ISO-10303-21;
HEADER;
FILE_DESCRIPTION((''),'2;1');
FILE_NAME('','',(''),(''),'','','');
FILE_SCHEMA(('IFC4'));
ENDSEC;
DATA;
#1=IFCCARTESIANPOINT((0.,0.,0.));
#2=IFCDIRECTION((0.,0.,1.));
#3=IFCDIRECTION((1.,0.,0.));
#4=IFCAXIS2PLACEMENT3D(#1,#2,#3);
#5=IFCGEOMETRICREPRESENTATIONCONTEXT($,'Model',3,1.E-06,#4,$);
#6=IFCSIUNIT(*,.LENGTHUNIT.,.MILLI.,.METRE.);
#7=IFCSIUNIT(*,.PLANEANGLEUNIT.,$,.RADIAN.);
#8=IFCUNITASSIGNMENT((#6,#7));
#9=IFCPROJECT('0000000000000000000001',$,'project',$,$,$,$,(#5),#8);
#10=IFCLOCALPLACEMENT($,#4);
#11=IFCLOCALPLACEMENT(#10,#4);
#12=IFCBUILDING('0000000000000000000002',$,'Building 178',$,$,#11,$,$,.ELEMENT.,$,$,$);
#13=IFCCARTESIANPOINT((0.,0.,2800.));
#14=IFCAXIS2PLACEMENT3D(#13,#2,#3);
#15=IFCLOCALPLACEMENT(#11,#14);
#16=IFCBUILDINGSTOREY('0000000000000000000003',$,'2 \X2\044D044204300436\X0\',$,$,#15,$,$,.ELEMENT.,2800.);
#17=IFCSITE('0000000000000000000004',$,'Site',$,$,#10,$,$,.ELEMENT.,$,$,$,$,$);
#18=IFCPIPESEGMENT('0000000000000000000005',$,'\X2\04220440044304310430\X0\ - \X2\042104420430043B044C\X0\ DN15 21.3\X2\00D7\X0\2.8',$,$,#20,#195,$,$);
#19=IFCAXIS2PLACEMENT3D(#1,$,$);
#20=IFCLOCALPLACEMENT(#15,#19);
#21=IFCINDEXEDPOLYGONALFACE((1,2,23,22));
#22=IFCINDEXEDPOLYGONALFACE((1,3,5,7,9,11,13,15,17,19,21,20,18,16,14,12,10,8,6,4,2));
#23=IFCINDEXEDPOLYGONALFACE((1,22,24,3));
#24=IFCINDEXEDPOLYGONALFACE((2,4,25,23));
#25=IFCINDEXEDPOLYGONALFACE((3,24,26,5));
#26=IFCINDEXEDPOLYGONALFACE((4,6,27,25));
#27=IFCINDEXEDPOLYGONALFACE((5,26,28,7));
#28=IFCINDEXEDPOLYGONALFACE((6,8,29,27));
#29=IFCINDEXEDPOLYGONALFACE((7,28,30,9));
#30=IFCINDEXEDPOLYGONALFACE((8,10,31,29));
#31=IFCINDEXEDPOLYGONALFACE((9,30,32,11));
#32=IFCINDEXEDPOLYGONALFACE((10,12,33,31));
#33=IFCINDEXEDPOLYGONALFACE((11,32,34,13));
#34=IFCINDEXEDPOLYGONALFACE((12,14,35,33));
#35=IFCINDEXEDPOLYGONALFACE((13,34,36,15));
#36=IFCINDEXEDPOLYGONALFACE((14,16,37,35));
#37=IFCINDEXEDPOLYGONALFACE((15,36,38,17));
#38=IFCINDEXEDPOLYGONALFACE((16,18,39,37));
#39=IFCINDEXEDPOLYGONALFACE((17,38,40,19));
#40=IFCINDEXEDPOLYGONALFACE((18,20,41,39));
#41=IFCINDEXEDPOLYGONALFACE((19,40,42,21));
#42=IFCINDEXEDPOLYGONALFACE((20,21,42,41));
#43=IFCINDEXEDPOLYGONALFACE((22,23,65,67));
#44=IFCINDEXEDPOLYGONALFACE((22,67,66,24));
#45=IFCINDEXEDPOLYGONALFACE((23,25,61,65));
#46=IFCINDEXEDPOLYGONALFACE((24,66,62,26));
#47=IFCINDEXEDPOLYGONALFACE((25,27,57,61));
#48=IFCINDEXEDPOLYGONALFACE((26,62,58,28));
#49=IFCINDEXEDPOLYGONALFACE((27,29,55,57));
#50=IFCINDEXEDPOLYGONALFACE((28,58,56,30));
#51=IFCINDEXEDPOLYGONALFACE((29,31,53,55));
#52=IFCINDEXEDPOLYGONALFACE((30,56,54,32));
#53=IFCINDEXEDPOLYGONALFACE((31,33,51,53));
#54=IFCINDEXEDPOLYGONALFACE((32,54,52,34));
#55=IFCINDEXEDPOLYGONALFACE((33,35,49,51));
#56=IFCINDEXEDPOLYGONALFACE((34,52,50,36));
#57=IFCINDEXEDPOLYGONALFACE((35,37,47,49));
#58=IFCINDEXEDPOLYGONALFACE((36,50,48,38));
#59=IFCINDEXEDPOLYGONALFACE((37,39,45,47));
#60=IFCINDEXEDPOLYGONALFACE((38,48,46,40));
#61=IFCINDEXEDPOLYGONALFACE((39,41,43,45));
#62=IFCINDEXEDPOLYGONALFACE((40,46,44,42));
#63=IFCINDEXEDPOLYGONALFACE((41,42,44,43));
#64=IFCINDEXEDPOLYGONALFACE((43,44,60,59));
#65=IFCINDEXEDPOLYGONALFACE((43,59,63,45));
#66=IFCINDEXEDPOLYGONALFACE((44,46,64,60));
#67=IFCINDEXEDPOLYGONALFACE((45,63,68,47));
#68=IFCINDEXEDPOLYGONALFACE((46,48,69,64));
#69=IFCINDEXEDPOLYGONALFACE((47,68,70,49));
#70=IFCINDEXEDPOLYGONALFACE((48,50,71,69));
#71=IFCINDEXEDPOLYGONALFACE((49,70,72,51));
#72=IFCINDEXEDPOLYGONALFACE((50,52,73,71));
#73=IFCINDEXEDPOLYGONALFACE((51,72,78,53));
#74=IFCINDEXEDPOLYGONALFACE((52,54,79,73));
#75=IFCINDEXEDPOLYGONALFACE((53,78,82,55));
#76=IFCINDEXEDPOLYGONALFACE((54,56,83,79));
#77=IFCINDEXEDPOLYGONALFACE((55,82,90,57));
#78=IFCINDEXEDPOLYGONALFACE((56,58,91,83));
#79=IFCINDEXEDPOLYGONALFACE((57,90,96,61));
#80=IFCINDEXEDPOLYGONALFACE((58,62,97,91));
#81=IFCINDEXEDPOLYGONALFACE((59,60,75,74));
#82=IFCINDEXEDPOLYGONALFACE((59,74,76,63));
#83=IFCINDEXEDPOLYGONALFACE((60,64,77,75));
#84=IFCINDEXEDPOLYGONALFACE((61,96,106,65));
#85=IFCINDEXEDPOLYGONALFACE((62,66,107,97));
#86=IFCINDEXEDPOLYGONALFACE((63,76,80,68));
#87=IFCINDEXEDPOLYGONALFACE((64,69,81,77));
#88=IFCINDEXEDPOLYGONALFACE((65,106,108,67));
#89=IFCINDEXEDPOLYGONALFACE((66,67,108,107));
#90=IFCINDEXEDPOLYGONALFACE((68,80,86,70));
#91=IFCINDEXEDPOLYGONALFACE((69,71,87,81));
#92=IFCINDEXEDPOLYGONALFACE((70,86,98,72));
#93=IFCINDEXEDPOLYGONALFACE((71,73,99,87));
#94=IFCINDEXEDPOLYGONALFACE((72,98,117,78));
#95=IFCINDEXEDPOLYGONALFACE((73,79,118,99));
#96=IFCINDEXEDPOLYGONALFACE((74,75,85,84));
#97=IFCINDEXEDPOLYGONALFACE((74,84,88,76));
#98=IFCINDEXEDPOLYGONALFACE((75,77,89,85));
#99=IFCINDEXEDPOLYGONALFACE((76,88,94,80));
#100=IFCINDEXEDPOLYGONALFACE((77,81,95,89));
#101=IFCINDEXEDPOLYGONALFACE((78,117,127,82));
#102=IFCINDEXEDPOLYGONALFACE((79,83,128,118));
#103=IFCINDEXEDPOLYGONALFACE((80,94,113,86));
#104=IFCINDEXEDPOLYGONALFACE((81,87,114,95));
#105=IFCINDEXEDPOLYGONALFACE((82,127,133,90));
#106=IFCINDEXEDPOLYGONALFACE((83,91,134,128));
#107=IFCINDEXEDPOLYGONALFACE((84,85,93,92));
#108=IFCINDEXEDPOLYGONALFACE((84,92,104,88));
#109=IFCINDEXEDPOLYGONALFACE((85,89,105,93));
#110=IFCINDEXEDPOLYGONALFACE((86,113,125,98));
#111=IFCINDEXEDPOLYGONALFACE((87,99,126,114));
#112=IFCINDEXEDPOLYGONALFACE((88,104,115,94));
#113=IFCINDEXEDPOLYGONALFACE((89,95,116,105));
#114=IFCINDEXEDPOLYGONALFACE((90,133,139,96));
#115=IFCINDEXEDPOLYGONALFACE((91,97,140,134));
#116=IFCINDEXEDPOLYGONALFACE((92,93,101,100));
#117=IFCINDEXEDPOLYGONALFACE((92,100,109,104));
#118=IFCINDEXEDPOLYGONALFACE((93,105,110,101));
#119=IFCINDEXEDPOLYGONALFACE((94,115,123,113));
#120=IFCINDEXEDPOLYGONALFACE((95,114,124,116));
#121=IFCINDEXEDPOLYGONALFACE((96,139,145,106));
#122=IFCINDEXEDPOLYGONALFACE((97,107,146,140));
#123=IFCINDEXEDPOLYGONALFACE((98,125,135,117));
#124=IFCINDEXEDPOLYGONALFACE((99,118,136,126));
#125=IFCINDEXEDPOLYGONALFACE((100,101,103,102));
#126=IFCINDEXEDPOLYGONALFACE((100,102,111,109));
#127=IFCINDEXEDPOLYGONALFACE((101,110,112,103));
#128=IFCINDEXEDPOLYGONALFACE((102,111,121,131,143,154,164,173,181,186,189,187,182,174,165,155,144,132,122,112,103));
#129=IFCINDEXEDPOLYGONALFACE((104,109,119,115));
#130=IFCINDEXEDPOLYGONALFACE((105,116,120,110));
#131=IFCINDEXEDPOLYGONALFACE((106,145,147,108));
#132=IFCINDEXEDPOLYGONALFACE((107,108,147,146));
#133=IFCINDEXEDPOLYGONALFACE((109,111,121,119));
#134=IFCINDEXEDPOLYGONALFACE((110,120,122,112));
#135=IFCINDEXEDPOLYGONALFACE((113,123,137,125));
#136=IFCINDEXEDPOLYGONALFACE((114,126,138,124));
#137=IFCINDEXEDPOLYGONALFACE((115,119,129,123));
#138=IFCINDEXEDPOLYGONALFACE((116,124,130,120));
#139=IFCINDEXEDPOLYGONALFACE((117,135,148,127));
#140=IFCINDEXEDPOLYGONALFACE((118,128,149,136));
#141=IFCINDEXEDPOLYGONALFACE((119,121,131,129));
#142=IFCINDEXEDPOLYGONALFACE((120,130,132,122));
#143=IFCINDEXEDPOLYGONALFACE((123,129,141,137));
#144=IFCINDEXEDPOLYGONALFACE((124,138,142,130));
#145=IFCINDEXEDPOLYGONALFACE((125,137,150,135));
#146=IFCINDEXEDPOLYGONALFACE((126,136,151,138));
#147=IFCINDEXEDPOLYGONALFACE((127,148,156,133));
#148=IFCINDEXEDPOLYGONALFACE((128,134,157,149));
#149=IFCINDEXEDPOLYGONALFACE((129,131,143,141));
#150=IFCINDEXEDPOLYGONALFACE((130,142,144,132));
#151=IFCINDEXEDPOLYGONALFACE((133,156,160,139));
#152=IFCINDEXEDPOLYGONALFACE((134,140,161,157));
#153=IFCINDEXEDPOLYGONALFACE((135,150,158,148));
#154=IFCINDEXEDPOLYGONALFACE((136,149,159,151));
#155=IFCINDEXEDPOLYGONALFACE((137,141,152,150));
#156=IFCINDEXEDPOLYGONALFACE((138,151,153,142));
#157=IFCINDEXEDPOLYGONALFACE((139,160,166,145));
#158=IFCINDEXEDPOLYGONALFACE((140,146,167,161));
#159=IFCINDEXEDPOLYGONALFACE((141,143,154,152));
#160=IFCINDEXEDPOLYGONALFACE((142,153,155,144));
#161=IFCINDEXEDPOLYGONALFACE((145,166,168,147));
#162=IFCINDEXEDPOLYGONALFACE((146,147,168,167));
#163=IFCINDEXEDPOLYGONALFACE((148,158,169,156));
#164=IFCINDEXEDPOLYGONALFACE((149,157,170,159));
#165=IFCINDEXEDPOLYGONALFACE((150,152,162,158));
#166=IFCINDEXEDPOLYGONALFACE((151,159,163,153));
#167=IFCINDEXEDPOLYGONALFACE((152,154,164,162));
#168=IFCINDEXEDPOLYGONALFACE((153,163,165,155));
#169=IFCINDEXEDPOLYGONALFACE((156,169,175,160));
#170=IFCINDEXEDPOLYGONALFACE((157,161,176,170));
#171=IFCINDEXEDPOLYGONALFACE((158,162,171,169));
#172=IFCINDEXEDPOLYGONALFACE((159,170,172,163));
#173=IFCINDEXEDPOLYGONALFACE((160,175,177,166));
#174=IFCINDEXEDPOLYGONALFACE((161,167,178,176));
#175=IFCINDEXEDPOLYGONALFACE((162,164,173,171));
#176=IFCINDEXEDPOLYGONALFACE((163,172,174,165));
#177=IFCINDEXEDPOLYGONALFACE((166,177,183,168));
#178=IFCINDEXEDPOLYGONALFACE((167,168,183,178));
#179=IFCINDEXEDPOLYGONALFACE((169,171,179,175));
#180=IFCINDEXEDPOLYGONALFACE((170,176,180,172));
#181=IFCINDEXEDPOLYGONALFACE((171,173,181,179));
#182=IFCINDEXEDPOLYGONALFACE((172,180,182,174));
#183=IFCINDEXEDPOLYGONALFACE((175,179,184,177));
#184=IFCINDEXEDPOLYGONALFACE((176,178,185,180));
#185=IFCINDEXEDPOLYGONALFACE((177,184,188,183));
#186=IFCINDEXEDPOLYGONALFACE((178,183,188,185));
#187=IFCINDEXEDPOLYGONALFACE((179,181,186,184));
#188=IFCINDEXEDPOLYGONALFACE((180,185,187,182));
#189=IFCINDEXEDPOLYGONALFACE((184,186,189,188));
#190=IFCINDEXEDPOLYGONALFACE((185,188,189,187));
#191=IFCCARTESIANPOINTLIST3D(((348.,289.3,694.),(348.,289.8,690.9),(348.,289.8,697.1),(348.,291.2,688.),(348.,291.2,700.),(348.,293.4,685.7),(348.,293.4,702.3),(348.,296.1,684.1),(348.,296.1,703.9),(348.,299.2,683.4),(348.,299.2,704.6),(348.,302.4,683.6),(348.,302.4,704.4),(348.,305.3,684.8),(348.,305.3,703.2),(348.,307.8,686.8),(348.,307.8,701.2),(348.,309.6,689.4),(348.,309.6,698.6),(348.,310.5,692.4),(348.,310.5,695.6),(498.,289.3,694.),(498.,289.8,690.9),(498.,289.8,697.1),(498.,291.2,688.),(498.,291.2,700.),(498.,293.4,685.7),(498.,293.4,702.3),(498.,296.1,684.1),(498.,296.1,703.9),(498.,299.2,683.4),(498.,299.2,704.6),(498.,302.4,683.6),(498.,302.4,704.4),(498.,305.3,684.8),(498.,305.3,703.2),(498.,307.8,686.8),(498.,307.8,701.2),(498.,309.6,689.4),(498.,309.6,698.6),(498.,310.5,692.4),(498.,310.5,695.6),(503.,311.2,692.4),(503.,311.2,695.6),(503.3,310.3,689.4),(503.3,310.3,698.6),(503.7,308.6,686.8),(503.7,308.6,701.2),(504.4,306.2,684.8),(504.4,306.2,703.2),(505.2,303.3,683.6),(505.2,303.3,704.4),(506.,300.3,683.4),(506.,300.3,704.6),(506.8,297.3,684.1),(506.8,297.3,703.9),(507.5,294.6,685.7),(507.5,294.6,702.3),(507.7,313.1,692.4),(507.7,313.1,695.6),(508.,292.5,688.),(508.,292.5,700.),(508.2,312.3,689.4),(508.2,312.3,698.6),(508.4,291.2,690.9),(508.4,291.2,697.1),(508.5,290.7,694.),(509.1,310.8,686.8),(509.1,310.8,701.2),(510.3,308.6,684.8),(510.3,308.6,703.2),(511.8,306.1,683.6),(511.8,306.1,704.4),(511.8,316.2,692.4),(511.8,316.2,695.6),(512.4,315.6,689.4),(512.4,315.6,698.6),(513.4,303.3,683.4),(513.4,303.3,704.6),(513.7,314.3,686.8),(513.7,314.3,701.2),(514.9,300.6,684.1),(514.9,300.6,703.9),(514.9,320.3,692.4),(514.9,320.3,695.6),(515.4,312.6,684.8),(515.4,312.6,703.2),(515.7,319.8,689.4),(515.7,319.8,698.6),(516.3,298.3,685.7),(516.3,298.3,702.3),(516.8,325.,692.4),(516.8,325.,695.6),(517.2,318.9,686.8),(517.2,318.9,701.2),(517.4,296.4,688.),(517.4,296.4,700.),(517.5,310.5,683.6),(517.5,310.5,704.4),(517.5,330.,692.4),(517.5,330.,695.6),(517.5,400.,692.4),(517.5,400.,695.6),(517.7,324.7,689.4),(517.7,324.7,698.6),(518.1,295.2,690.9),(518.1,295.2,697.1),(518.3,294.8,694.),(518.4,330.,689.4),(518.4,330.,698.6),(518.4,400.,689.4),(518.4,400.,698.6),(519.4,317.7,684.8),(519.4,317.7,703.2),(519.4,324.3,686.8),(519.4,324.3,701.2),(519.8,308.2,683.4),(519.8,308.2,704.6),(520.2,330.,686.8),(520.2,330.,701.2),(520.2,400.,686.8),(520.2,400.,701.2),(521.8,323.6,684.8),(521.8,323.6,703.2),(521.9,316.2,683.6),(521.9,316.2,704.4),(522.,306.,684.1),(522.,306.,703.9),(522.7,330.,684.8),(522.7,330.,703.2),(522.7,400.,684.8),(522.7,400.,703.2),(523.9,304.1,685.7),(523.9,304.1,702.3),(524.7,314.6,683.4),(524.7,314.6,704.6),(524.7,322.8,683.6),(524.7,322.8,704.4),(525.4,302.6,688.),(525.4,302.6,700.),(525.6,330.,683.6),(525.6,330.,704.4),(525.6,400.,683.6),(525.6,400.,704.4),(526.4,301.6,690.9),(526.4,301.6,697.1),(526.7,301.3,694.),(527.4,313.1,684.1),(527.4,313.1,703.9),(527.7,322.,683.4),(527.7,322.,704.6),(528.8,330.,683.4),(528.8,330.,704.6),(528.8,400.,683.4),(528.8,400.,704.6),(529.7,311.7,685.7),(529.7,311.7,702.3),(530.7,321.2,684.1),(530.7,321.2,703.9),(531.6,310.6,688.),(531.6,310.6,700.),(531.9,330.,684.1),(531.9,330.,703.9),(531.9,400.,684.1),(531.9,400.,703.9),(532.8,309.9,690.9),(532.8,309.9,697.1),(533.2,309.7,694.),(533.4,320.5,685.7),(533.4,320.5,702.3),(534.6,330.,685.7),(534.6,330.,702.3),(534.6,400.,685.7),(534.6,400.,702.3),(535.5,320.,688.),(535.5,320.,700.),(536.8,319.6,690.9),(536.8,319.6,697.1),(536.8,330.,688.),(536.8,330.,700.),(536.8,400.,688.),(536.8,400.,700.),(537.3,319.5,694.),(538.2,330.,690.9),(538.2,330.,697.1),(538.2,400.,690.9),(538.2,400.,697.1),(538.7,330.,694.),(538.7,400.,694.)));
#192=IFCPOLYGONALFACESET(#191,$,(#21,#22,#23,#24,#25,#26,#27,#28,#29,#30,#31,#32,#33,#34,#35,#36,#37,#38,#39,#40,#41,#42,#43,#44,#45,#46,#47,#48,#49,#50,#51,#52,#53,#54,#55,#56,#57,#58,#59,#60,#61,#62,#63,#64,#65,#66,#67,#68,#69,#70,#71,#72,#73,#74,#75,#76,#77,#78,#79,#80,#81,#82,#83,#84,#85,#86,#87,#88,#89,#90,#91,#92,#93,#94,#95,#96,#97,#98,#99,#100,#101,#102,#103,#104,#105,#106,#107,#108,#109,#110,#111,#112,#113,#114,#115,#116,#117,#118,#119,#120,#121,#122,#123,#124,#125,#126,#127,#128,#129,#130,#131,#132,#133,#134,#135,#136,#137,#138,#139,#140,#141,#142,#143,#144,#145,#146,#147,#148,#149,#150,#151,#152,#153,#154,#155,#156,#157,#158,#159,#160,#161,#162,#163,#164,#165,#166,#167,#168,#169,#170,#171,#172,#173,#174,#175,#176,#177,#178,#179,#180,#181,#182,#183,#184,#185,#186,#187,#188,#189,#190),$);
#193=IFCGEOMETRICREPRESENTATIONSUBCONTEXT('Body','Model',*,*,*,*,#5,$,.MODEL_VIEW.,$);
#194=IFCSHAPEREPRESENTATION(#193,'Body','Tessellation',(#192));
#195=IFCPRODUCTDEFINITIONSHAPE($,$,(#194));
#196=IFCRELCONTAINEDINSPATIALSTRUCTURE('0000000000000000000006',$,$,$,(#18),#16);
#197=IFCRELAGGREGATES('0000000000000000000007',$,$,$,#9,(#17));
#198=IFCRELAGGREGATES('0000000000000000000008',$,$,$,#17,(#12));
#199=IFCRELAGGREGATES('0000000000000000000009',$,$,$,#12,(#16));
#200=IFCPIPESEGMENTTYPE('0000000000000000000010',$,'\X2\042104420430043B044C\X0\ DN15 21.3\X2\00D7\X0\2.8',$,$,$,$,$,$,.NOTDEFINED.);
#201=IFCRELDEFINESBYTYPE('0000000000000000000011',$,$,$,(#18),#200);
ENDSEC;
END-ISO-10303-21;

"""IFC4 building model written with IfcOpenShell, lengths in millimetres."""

from ifc_helpers import new_model, entity, si_unit, frame, origin_with_axes, place, context, subcontext, project, spatial, source, transform, mapped, type_object, element, save


model = new_model("IFC4")

# Units and contexts
model_context = context("Model", 3, precision=1e-06, world=origin_with_axes())
body_context = subcontext(model_context, "Body", "Model", "MODEL_VIEW")
ifc_project = project(units=[si_unit("LENGTHUNIT", "METRE", prefix="MILLI"), si_unit("PLANEANGLEUNIT", "RADIAN")], contexts=[model_context])

# Site, building, storey
site_placement = place(None, origin_with_axes())
site = spatial("IfcSite", under=ifc_project, at=site_placement, Name="Site", CompositionType="ELEMENT")
building_placement = place(site_placement, origin_with_axes())
building = spatial("IfcBuilding", under=site, at=building_placement, Name="Building 178", CompositionType="ELEMENT")
storey_placement = place(building_placement, frame((0.0, 0.0, 2800.0), z_axis=(0.0, 0.0, 1.0), x_axis=(1.0, 0.0, 0.0)))
storey = spatial("IfcBuildingStorey", under=building, at=storey_placement, Name="2 этаж", CompositionType="ELEMENT", Elevation=2800.0)

# Pipe segment
pipe_segment_type = type_object("IfcPipeSegmentType", Name="Сталь DN15 21.3×2.8", PredefinedType="NOTDEFINED")
shared_shape_1 = source(origin_with_axes(), body_context, "Body", "AdvancedSweptSolid", [
    entity("IfcSweptDiskSolid", entity("IfcIndexedPolyCurve", entity("IfcCartesianPointList3D", [[0.0, 0.0, 0.0], [0.0, 0.0, -70.0], [8.8, 0.0, -91.2], [30.0, 0.0, -100.0], [180.0, 0.0, -100.0]]), [entity("IfcLineIndex", [1, 2]), entity("IfcArcIndex", [2, 3, 4]), entity("IfcLineIndex", [4, 5])]), 10.7),
])
for number, where, z_axis, x_axis, name in (
    (1, (528.0, 400.0, 694.0), (0.0, 1.0, 0.0), (-1.0, 0.0, 0.0), "Труба - Сталь DN15 21.3×2.8"),
):
    element("IfcPipeSegment", number, at=place(storey_placement, frame(where, z_axis=z_axis, x_axis=x_axis)), inside=storey, type_object=pipe_segment_type, Name=name, context=body_context, shape_type="MappedRepresentation", body=[
        mapped(shared_shape_1, transform((0.0, 0.0, 0.0), x_axis=(1.0, 0.0, 0.0), y_axis=(0.0, 1.0, 0.0), z_axis=(0.0, 0.0, 1.0), scale=1.0)),
    ])

save(model, "model.ifc")
